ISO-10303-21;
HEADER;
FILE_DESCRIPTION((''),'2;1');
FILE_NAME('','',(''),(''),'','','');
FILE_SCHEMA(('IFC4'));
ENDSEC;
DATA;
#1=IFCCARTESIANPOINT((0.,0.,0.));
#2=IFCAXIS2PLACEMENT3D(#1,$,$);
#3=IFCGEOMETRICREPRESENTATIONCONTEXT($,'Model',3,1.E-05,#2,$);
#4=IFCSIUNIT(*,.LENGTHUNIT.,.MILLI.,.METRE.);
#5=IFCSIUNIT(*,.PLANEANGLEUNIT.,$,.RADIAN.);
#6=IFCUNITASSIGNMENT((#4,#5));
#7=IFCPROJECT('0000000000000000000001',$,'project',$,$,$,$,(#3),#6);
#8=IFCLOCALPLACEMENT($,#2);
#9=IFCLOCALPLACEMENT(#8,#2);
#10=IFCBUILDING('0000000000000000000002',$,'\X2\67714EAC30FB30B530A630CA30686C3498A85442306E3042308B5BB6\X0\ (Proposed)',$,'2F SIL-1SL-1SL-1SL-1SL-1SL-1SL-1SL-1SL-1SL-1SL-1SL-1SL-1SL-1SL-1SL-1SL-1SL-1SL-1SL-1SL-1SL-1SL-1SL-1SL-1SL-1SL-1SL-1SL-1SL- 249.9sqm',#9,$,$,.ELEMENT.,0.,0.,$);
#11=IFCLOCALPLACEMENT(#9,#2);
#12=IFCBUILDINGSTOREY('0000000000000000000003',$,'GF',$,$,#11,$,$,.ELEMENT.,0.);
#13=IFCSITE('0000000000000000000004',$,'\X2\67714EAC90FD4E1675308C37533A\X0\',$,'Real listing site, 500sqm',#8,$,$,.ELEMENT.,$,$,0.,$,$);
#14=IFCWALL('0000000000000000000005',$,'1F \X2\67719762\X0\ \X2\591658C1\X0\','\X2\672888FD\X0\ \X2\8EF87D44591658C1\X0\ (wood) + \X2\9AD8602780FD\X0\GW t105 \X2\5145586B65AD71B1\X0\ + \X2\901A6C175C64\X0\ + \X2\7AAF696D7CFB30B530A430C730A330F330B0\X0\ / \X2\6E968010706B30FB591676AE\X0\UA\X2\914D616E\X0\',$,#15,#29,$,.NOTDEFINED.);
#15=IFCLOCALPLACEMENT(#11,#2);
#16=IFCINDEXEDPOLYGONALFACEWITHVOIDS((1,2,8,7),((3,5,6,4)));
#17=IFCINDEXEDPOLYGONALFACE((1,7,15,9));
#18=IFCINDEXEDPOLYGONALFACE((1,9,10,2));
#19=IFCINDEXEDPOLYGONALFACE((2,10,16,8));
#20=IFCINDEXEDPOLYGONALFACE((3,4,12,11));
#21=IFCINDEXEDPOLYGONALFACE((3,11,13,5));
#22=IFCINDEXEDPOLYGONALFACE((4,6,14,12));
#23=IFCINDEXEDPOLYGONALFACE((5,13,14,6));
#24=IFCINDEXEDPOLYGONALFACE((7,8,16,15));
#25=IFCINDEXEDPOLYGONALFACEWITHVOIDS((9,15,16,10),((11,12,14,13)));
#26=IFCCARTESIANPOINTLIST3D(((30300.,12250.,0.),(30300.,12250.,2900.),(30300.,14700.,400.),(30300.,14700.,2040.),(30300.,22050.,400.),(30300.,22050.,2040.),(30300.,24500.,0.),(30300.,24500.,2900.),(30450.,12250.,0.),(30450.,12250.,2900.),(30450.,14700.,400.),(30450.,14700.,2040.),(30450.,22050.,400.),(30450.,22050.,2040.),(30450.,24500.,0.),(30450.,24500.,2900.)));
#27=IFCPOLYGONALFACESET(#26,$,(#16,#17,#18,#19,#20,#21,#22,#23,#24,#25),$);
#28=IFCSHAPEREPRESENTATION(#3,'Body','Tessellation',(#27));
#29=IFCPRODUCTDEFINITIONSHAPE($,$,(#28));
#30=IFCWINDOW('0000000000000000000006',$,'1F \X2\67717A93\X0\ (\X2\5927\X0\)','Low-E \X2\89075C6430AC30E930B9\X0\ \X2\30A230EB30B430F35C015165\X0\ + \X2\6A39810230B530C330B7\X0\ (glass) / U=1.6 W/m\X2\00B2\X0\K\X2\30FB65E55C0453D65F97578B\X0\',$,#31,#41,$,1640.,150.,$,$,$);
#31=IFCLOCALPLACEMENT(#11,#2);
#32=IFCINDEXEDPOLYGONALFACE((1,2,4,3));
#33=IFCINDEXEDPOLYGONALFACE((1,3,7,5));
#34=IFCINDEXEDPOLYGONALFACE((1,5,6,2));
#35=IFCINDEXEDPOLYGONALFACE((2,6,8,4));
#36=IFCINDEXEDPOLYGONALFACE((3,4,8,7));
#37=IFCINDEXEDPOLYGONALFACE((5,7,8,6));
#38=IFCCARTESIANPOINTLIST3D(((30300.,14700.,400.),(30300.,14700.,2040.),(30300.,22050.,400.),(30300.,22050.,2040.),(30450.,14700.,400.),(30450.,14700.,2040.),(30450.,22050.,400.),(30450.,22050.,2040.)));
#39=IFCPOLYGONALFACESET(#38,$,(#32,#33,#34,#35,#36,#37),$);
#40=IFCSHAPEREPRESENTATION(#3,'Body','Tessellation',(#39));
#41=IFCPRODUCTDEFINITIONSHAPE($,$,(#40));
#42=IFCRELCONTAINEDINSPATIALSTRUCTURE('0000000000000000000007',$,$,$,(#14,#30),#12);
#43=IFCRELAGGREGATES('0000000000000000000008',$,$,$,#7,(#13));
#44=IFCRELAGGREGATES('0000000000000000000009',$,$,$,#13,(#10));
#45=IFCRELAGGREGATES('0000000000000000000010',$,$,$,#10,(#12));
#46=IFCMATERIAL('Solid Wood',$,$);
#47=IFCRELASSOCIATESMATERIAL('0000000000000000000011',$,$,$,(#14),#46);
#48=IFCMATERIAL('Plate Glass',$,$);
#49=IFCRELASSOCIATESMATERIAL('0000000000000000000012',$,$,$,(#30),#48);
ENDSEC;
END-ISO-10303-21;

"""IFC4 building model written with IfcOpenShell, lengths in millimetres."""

from ifc_helpers import new_model, si_unit, frame, frame_2d, origin, place, context, project, spatial, rectangle, extrude, material, element, fill, save


model = new_model("IFC4")

# Units and contexts
model_context = context("Model", 3, precision=1e-05, world=origin())
ifc_project = project(units=[si_unit("LENGTHUNIT", "METRE", prefix="MILLI"), si_unit("PLANEANGLEUNIT", "RADIAN")], contexts=[model_context])

# Site, building, storey
site_placement = place(None, origin())
site = spatial("IfcSite", under=ifc_project, at=site_placement, Name="東京都世田谷区", ObjectType="Real listing site, 500sqm", CompositionType="ELEMENT", RefElevation=0.0)
building_placement = place(site_placement, origin())
building = spatial("IfcBuilding", under=site, at=building_placement, Name="東京・サウナと水風呂のある家 (Proposed)", ObjectType="2F SIL-1SL-1SL-1SL-1SL-1SL-1SL-1SL-1SL-1SL-1SL-1SL-1SL-1SL-1SL-1SL-1SL-1SL-1SL-1SL-1SL-1SL-1SL-1SL-1SL-1SL-1SL-1SL-1SL-1SL- 249.9sqm", CompositionType="ELEMENT", ElevationOfRefHeight=0.0, ElevationOfTerrain=0.0)
storey_placement = place(building_placement, origin())
storey = spatial("IfcBuildingStorey", under=building, at=storey_placement, Name="GF", CompositionType="ELEMENT", Elevation=0.0)

# Shared definitions
ifc_material_1 = material(Name="Solid Wood")

# Wall, opening, window
wall_1_placement = place(storey_placement, frame((15150.0, 6125.0, 0.0)))
wall_1 = element("IfcWall", 1, at=wall_1_placement, inside=storey, material=ifc_material_1, Name="1F 東面 外壁", Description="木製 軸組外壁 (wood) + 高性能GW t105 充填断熱 + 通気層 + 窯業系サイディング / 準耐火・外皮UA配慮", PredefinedType="NOTDEFINED", context=model_context, shape_type="SweptSolid", body=[
    extrude(rectangle(XDim=150.0, YDim=12250.0, at=frame_2d((75.0, 6125.0))), frame((15150.0, 6125.0, 0.0)), (0.0, 0.0, 1.0), 2900.0),
])
opening_1_placement = place(storey_placement, frame((15150.0, 7350.0, 200.0)))
opening_1 = element("IfcOpeningElement", 2, at=opening_1_placement, cuts=wall_1, PredefinedType="NOTDEFINED", context=model_context, shape_type="SweptSolid", body=[
    extrude(rectangle(XDim=150.0, YDim=7350.0, at=frame_2d((75.0, 3675.0))), frame((15150.0, 7350.0, 200.0)), (0.0, 0.0, 1.0), 1640.0),
])
ifc_material_2 = material(Name="Plate Glass")
window_1_placement = place(storey_placement, frame((15150.0, 7350.0, 200.0)))
window_1 = element("IfcWindow", 3, at=window_1_placement, inside=storey, material=ifc_material_2, Name="1F 東窓 (大)", Description="Low-E 複層ガラス アルゴン封入 + 樹脂サッシ (glass) / U=1.6 W/m²K・日射取得型", OverallHeight=1640.0, OverallWidth=150.0, context=model_context, shape_type="SweptSolid", body=[
    extrude(rectangle(XDim=150.0, YDim=7350.0, at=frame_2d((75.0, 3675.0))), frame((15150.0, 7350.0, 200.0)), (0.0, 0.0, 1.0), 1640.0),
])
fill(opening_1, window_1)

save(model, "model.ifc")
